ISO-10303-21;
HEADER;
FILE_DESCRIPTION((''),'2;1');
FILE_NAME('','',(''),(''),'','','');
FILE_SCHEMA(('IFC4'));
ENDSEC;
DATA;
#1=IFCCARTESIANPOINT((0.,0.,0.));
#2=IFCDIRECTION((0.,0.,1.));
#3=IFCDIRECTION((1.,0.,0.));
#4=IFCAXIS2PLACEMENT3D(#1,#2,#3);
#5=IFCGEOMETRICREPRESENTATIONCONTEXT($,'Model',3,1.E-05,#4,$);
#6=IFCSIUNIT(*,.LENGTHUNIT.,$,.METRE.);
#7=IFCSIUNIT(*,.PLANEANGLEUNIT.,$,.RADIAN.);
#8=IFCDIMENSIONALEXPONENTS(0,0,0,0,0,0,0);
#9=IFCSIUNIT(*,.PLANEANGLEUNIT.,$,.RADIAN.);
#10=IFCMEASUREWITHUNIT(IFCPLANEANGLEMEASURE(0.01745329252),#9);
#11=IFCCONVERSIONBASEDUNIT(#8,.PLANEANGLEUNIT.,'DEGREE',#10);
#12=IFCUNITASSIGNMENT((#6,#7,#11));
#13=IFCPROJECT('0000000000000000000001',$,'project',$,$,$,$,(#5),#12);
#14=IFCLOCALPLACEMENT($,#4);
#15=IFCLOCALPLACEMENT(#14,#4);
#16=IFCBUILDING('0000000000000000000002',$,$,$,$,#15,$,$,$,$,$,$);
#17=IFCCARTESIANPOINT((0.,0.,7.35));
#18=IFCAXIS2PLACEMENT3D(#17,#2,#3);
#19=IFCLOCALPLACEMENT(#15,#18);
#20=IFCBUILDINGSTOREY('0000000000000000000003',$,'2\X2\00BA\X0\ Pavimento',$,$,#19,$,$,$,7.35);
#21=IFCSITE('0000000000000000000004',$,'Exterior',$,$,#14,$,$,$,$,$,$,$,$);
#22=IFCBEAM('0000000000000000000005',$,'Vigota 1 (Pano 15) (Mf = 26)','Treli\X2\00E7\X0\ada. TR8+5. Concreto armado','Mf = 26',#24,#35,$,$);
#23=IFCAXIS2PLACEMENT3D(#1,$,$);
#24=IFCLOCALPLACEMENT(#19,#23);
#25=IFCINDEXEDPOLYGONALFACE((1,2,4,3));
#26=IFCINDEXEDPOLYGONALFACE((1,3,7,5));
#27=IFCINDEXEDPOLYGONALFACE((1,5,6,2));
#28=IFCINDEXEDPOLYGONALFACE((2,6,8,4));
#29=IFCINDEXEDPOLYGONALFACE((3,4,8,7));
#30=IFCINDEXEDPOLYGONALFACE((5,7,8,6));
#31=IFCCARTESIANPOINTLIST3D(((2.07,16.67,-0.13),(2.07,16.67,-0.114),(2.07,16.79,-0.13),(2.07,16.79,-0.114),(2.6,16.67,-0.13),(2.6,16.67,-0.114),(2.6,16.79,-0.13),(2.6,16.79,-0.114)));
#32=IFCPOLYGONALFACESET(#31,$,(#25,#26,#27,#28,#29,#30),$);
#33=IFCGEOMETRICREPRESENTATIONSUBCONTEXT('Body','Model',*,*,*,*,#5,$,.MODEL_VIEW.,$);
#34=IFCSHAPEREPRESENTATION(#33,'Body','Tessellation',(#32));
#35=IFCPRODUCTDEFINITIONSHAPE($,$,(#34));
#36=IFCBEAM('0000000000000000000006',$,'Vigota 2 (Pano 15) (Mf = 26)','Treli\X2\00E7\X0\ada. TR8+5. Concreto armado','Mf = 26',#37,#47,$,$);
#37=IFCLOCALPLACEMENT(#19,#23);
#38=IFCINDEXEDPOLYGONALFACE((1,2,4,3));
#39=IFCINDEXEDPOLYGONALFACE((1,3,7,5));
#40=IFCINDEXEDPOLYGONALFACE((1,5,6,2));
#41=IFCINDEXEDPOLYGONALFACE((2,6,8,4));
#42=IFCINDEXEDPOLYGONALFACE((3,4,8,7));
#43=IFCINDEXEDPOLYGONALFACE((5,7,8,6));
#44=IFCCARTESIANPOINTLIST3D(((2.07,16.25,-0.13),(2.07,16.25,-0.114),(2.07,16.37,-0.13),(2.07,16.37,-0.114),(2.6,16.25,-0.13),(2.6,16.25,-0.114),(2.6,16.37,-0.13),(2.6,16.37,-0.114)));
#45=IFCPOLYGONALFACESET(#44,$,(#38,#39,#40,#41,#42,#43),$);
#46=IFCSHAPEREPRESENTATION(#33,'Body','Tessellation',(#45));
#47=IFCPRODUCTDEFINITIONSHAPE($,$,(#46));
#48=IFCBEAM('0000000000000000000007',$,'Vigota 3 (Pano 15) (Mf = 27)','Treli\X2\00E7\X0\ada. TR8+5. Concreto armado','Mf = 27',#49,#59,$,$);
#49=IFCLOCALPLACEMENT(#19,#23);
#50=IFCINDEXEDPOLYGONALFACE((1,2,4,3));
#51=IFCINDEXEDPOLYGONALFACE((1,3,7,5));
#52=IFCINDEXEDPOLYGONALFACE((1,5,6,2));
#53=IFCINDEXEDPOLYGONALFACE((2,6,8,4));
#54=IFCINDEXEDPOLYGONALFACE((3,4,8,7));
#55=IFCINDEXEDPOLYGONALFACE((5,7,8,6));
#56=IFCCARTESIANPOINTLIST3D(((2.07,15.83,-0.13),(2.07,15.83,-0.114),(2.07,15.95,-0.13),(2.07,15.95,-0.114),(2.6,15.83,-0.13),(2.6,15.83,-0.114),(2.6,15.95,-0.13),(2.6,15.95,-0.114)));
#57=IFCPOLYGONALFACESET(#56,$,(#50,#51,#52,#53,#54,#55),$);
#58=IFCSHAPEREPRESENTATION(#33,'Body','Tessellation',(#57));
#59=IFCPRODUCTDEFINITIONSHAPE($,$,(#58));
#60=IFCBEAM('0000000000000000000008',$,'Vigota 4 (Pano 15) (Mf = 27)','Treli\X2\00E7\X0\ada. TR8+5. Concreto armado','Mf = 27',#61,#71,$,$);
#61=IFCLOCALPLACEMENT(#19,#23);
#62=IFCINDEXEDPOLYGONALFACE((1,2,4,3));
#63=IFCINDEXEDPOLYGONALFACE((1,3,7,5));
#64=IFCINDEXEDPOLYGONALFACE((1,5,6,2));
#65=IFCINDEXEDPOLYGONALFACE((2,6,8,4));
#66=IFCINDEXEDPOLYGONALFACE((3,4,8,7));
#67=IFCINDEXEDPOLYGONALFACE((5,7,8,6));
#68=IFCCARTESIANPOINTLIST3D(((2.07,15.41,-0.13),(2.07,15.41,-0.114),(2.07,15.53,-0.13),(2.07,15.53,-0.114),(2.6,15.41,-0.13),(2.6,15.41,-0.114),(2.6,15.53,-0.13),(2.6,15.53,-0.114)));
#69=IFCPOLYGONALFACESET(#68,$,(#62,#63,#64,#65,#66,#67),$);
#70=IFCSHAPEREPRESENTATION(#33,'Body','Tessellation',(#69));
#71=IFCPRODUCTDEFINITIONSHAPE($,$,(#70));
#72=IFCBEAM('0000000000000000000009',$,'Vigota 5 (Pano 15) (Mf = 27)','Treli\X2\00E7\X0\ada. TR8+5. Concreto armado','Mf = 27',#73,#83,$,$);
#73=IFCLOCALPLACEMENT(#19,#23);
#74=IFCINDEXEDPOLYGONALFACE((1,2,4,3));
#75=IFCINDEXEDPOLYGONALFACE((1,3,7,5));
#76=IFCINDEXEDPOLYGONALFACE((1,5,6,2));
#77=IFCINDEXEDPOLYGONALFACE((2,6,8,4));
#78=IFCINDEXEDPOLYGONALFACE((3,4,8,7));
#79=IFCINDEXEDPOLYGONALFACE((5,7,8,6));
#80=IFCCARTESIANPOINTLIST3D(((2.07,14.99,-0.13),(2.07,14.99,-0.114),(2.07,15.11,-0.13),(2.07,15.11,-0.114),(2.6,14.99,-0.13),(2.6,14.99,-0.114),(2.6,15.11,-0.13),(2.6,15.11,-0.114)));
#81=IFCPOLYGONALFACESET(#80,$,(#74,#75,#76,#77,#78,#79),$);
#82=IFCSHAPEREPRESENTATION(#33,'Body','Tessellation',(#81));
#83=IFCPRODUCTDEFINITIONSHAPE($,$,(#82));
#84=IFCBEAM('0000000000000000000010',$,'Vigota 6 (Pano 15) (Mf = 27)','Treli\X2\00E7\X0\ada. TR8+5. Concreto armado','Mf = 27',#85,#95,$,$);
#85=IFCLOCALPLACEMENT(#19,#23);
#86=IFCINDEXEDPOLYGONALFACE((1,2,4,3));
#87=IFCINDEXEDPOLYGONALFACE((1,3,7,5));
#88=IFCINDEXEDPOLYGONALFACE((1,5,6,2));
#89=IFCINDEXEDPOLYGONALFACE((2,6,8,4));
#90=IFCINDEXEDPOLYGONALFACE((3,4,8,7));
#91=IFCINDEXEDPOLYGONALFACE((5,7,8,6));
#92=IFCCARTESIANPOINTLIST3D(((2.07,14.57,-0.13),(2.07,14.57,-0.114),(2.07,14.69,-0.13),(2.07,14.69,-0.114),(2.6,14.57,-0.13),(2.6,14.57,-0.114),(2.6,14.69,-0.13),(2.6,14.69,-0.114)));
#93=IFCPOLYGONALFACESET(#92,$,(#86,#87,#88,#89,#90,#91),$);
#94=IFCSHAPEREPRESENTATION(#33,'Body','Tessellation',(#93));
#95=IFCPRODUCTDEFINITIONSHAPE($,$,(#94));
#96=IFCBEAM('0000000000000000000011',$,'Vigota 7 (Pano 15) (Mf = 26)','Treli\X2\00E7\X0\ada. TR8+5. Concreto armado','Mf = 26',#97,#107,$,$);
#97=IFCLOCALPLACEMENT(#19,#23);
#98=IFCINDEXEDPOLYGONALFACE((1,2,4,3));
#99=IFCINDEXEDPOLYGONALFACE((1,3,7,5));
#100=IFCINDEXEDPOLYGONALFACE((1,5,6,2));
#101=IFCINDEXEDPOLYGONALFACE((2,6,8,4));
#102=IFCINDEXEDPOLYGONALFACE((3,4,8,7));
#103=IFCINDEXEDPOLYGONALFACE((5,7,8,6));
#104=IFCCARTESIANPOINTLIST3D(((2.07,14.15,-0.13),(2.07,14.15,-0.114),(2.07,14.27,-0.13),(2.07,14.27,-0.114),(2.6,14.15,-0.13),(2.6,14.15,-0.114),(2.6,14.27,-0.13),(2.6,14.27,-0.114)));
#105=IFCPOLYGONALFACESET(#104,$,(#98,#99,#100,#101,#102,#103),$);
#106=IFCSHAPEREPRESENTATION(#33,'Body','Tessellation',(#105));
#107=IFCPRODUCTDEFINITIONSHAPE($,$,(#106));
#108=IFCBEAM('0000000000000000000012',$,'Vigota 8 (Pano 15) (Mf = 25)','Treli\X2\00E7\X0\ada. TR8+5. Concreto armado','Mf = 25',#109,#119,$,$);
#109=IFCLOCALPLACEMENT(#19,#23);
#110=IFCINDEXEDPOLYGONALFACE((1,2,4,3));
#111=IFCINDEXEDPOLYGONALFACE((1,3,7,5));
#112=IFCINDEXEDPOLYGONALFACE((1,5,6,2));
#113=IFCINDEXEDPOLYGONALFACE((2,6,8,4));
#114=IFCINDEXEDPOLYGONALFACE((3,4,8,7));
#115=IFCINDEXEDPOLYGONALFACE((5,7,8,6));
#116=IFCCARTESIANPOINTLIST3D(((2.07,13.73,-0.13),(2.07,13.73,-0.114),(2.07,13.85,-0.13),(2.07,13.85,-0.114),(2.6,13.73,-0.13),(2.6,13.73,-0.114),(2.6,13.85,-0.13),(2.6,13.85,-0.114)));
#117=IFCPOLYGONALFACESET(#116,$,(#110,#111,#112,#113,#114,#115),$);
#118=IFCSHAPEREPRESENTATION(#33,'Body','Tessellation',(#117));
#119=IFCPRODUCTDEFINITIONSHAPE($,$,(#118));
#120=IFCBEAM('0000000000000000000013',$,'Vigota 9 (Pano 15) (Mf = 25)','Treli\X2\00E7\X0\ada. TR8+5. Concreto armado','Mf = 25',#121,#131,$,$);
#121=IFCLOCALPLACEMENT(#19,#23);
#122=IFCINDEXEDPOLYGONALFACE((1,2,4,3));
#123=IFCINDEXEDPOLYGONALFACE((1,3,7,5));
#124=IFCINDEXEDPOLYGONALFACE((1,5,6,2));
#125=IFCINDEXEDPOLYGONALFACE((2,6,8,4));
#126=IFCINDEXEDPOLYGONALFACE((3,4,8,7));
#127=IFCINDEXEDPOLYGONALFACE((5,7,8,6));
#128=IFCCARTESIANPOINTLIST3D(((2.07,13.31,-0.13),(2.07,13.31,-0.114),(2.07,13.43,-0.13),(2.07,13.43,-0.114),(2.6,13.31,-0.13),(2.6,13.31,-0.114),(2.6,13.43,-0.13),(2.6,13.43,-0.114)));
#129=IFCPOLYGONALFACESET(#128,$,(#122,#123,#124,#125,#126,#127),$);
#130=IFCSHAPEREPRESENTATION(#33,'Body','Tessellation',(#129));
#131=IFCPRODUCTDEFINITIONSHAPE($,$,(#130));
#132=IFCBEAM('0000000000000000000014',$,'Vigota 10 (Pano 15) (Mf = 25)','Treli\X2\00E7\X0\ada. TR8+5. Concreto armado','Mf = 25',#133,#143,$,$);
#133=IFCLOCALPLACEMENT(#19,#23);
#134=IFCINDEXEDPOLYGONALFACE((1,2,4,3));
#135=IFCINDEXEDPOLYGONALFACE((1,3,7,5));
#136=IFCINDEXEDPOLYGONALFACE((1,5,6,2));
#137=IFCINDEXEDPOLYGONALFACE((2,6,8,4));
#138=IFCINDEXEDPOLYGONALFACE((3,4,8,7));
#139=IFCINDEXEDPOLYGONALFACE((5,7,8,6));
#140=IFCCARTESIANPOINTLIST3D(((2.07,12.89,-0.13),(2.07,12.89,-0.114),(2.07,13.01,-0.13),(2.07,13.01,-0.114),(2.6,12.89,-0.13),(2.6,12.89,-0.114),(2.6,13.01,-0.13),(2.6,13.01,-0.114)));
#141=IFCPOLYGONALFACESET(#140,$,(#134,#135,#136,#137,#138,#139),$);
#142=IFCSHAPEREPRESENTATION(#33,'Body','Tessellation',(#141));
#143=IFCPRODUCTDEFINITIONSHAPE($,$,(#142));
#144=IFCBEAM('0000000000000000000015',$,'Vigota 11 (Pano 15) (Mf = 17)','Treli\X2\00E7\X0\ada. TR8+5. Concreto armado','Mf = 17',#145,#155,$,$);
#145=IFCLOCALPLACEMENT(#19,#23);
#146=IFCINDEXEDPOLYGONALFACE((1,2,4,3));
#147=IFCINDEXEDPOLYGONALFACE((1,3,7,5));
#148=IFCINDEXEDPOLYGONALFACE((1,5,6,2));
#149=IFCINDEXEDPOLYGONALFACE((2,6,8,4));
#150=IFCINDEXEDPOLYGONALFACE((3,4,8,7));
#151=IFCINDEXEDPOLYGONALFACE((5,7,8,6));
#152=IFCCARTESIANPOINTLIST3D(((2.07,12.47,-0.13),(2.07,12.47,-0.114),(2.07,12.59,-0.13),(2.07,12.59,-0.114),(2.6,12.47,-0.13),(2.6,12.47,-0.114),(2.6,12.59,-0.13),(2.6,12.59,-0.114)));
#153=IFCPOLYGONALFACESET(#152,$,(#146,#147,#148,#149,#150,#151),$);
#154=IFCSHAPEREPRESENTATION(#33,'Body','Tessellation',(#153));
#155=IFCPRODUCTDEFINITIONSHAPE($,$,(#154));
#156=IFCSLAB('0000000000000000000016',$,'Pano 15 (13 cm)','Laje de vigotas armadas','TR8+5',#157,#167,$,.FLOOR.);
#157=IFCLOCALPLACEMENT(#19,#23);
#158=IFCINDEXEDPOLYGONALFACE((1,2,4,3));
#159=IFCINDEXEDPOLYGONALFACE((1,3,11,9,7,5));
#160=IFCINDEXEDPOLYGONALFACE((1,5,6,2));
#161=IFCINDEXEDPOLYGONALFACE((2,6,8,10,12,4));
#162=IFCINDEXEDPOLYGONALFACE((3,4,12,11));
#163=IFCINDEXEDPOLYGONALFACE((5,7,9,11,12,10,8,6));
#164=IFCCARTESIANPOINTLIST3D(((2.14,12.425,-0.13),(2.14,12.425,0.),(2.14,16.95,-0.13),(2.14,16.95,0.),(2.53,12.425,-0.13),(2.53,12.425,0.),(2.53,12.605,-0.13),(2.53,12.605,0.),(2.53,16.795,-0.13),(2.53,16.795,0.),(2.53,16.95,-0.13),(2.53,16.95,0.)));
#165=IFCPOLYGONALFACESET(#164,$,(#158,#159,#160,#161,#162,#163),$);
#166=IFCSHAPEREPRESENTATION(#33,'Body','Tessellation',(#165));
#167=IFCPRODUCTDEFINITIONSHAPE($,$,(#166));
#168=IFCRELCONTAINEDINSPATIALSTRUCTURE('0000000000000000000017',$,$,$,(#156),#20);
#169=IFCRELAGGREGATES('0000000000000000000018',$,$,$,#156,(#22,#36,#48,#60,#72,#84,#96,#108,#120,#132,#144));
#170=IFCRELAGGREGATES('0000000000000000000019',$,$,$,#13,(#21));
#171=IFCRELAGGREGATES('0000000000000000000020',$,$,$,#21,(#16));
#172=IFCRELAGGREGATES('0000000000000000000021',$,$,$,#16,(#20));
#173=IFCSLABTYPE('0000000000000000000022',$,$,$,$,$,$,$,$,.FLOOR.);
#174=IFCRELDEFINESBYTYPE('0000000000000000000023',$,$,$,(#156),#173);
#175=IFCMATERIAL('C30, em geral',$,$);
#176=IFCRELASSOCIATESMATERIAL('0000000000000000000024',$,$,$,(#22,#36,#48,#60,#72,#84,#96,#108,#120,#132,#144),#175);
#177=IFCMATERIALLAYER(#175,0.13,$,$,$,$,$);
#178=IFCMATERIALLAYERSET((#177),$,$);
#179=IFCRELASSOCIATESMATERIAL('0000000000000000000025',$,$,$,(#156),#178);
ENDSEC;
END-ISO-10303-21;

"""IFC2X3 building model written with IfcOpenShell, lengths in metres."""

from ifc_helpers import new_model, entity, si_unit, converted_unit, frame, origin_with_axes, place, context, subcontext, project, spatial, polyline, outline, extrude, material, layer, layer_set, layer_usage, type_object, element, aggregate, save


model = new_model("IFC2X3")

# Units and contexts
model_context = context("Model", 3, precision=1e-05, world=origin_with_axes())
body_context = subcontext(model_context, "Body", "Model", "MODEL_VIEW")
ifc_project = project(units=[si_unit("LENGTHUNIT", "METRE"), si_unit("PLANEANGLEUNIT", "RADIAN"), converted_unit("PLANEANGLEUNIT", "DEGREE", entity("IfcPlaneAngleMeasure", 0.01745329252), si_unit("PLANEANGLEUNIT", "RADIAN"), dimensions=[0, 0, 0, 0, 0, 0, 0])], contexts=[model_context])

# Beams
ifc_material = material(Name="C30, em geral")
site_placement = place(None, origin_with_axes())
building_placement = place(site_placement, origin_with_axes())
storey_placement = place(building_placement, frame((0.0, 0.0, 7.35), z_axis=(0.0, 0.0, 1.0), x_axis=(1.0, 0.0, 0.0)))
beam_1_placement = place(storey_placement, frame((2.07, 16.73, -0.122), z_axis=(1.0, 0.0, 0.0), x_axis=(0.0, 1.0, 0.0)))
beam_1 = element("IfcBeam", 1, at=beam_1_placement, material=ifc_material, Name="Vigota 1 (Pano 15) (Mf = 26)", Description="Treliçada. TR8+5. Concreto armado", ObjectType="Mf = 26", context=body_context, shape_type="SweptSolid", body=[
    extrude(outline(polyline([(0.06, 0.008), (-0.06, 0.008), (-0.06, -0.008), (0.06, -0.008), (0.06, 0.008)])), origin_with_axes(), (0.0, 0.0, 1.0), 0.53),
])
beam_2_placement = place(storey_placement, frame((2.07, 16.31, -0.122), z_axis=(1.0, 0.0, 0.0), x_axis=(0.0, 1.0, 0.0)))
beam_2 = element("IfcBeam", 2, at=beam_2_placement, material=ifc_material, Name="Vigota 2 (Pano 15) (Mf = 26)", Description="Treliçada. TR8+5. Concreto armado", ObjectType="Mf = 26", context=body_context, shape_type="SweptSolid", body=[
    extrude(outline(polyline([(0.06, 0.008), (-0.06, 0.008), (-0.06, -0.008), (0.06, -0.008), (0.06, 0.008)])), origin_with_axes(), (0.0, 0.0, 1.0), 0.53),
])
beam_3_placement = place(storey_placement, frame((2.07, 15.89, -0.122), z_axis=(1.0, 0.0, 0.0), x_axis=(0.0, 1.0, 0.0)))
beam_3 = element("IfcBeam", 3, at=beam_3_placement, material=ifc_material, Name="Vigota 3 (Pano 15) (Mf = 27)", Description="Treliçada. TR8+5. Concreto armado", ObjectType="Mf = 27", context=body_context, shape_type="SweptSolid", body=[
    extrude(outline(polyline([(0.06, 0.008), (-0.06, 0.008), (-0.06, -0.008), (0.06, -0.008), (0.06, 0.008)])), origin_with_axes(), (0.0, 0.0, 1.0), 0.53),
])
beam_4_placement = place(storey_placement, frame((2.07, 15.47, -0.122), z_axis=(1.0, 0.0, 0.0), x_axis=(0.0, 1.0, 0.0)))
beam_4 = element("IfcBeam", 4, at=beam_4_placement, material=ifc_material, Name="Vigota 4 (Pano 15) (Mf = 27)", Description="Treliçada. TR8+5. Concreto armado", ObjectType="Mf = 27", context=body_context, shape_type="SweptSolid", body=[
    extrude(outline(polyline([(0.06, 0.008), (-0.06, 0.008), (-0.06, -0.008), (0.06, -0.008), (0.06, 0.008)])), origin_with_axes(), (0.0, 0.0, 1.0), 0.53),
])
beam_5_placement = place(storey_placement, frame((2.07, 15.05, -0.122), z_axis=(1.0, 0.0, 0.0), x_axis=(0.0, 1.0, 0.0)))
beam_5 = element("IfcBeam", 5, at=beam_5_placement, material=ifc_material, Name="Vigota 5 (Pano 15) (Mf = 27)", Description="Treliçada. TR8+5. Concreto armado", ObjectType="Mf = 27", context=body_context, shape_type="SweptSolid", body=[
    extrude(outline(polyline([(0.06, 0.008), (-0.06, 0.008), (-0.06, -0.008), (0.06, -0.008), (0.06, 0.008)])), origin_with_axes(), (0.0, 0.0, 1.0), 0.53),
])
beam_6_placement = place(storey_placement, frame((2.07, 14.63, -0.122), z_axis=(1.0, 0.0, 0.0), x_axis=(0.0, 1.0, 0.0)))
beam_6 = element("IfcBeam", 6, at=beam_6_placement, material=ifc_material, Name="Vigota 6 (Pano 15) (Mf = 27)", Description="Treliçada. TR8+5. Concreto armado", ObjectType="Mf = 27", context=body_context, shape_type="SweptSolid", body=[
    extrude(outline(polyline([(0.06, 0.008), (-0.06, 0.008), (-0.06, -0.008), (0.06, -0.008), (0.06, 0.008)])), origin_with_axes(), (0.0, 0.0, 1.0), 0.53),
])
beam_7_placement = place(storey_placement, frame((2.07, 14.21, -0.122), z_axis=(1.0, 0.0, 0.0), x_axis=(0.0, 1.0, 0.0)))
beam_7 = element("IfcBeam", 7, at=beam_7_placement, material=ifc_material, Name="Vigota 7 (Pano 15) (Mf = 26)", Description="Treliçada. TR8+5. Concreto armado", ObjectType="Mf = 26", context=body_context, shape_type="SweptSolid", body=[
    extrude(outline(polyline([(0.06, 0.008), (-0.06, 0.008), (-0.06, -0.008), (0.06, -0.008), (0.06, 0.008)])), origin_with_axes(), (0.0, 0.0, 1.0), 0.53),
])
beam_8_placement = place(storey_placement, frame((2.07, 13.79, -0.122), z_axis=(1.0, 0.0, 0.0), x_axis=(0.0, 1.0, 0.0)))
beam_8 = element("IfcBeam", 8, at=beam_8_placement, material=ifc_material, Name="Vigota 8 (Pano 15) (Mf = 25)", Description="Treliçada. TR8+5. Concreto armado", ObjectType="Mf = 25", context=body_context, shape_type="SweptSolid", body=[
    extrude(outline(polyline([(0.06, 0.008), (-0.06, 0.008), (-0.06, -0.008), (0.06, -0.008), (0.06, 0.008)])), origin_with_axes(), (0.0, 0.0, 1.0), 0.53),
])
beam_9_placement = place(storey_placement, frame((2.07, 13.37, -0.122), z_axis=(1.0, 0.0, 0.0), x_axis=(0.0, 1.0, 0.0)))
beam_9 = element("IfcBeam", 9, at=beam_9_placement, material=ifc_material, Name="Vigota 9 (Pano 15) (Mf = 25)", Description="Treliçada. TR8+5. Concreto armado", ObjectType="Mf = 25", context=body_context, shape_type="SweptSolid", body=[
    extrude(outline(polyline([(0.06, 0.008), (-0.06, 0.008), (-0.06, -0.008), (0.06, -0.008), (0.06, 0.008)])), origin_with_axes(), (0.0, 0.0, 1.0), 0.53),
])
beam_10_placement = place(storey_placement, frame((2.07, 12.95, -0.122), z_axis=(1.0, 0.0, 0.0), x_axis=(0.0, 1.0, 0.0)))
beam_10 = element("IfcBeam", 10, at=beam_10_placement, material=ifc_material, Name="Vigota 10 (Pano 15) (Mf = 25)", Description="Treliçada. TR8+5. Concreto armado", ObjectType="Mf = 25", context=body_context, shape_type="SweptSolid", body=[
    extrude(outline(polyline([(0.06, 0.008), (-0.06, 0.008), (-0.06, -0.008), (0.06, -0.008), (0.06, 0.008)])), origin_with_axes(), (0.0, 0.0, 1.0), 0.53),
])
beam_11_placement = place(storey_placement, frame((2.07, 12.53, -0.122), z_axis=(1.0, 0.0, 0.0), x_axis=(0.0, 1.0, 0.0)))
beam_11 = element("IfcBeam", 11, at=beam_11_placement, material=ifc_material, Name="Vigota 11 (Pano 15) (Mf = 17)", Description="Treliçada. TR8+5. Concreto armado", ObjectType="Mf = 17", context=body_context, shape_type="SweptSolid", body=[
    extrude(outline(polyline([(0.06, 0.008), (-0.06, 0.008), (-0.06, -0.008), (0.06, -0.008), (0.06, 0.008)])), origin_with_axes(), (0.0, 0.0, 1.0), 0.53),
])

# Site, building, storey
site = spatial("IfcSite", under=ifc_project, at=site_placement, Name="Exterior")
building = spatial("IfcBuilding", under=site, at=building_placement)
storey = spatial("IfcBuildingStorey", under=building, at=storey_placement, Name="2º Pavimento", Elevation=7.35)

# Slab
slab_type = type_object("IfcSlabType", PredefinedType="FLOOR")
ifc_layer_1 = layer(ifc_material, 0.13)
ifc_layer_set_1 = layer_set([ifc_layer_1])
ifc_layer_usage_1 = layer_usage(ifc_layer_set_1, "AXIS3", "POSITIVE", 0.0)
slab_1_placement = place(storey_placement, frame((0.0, 0.0, -0.13), z_axis=(0.0, 0.0, 1.0), x_axis=(1.0, 0.0, 0.0)))
slab_1 = element("IfcSlab", 12, at=slab_1_placement, inside=storey, type_object=slab_type, material=ifc_layer_usage_1, Name="Pano 15 (13 cm)", Description="Laje de vigotas armadas", ObjectType="TR8+5", PredefinedType="FLOOR", context=body_context, shape_type="SweptSolid", body=[
    extrude(outline(polyline([(2.53, 16.95), (2.14, 16.95), (2.14, 12.425), (2.53, 12.425), (2.53, 12.605), (2.53, 16.795), (2.53, 16.95)])), origin_with_axes(), (0.0, 0.0, 1.0), 0.13),
])
aggregate(slab_1, [beam_1, beam_2, beam_3, beam_4, beam_5, beam_6, beam_7, beam_8, beam_9, beam_10, beam_11])

save(model, "model.ifc")
